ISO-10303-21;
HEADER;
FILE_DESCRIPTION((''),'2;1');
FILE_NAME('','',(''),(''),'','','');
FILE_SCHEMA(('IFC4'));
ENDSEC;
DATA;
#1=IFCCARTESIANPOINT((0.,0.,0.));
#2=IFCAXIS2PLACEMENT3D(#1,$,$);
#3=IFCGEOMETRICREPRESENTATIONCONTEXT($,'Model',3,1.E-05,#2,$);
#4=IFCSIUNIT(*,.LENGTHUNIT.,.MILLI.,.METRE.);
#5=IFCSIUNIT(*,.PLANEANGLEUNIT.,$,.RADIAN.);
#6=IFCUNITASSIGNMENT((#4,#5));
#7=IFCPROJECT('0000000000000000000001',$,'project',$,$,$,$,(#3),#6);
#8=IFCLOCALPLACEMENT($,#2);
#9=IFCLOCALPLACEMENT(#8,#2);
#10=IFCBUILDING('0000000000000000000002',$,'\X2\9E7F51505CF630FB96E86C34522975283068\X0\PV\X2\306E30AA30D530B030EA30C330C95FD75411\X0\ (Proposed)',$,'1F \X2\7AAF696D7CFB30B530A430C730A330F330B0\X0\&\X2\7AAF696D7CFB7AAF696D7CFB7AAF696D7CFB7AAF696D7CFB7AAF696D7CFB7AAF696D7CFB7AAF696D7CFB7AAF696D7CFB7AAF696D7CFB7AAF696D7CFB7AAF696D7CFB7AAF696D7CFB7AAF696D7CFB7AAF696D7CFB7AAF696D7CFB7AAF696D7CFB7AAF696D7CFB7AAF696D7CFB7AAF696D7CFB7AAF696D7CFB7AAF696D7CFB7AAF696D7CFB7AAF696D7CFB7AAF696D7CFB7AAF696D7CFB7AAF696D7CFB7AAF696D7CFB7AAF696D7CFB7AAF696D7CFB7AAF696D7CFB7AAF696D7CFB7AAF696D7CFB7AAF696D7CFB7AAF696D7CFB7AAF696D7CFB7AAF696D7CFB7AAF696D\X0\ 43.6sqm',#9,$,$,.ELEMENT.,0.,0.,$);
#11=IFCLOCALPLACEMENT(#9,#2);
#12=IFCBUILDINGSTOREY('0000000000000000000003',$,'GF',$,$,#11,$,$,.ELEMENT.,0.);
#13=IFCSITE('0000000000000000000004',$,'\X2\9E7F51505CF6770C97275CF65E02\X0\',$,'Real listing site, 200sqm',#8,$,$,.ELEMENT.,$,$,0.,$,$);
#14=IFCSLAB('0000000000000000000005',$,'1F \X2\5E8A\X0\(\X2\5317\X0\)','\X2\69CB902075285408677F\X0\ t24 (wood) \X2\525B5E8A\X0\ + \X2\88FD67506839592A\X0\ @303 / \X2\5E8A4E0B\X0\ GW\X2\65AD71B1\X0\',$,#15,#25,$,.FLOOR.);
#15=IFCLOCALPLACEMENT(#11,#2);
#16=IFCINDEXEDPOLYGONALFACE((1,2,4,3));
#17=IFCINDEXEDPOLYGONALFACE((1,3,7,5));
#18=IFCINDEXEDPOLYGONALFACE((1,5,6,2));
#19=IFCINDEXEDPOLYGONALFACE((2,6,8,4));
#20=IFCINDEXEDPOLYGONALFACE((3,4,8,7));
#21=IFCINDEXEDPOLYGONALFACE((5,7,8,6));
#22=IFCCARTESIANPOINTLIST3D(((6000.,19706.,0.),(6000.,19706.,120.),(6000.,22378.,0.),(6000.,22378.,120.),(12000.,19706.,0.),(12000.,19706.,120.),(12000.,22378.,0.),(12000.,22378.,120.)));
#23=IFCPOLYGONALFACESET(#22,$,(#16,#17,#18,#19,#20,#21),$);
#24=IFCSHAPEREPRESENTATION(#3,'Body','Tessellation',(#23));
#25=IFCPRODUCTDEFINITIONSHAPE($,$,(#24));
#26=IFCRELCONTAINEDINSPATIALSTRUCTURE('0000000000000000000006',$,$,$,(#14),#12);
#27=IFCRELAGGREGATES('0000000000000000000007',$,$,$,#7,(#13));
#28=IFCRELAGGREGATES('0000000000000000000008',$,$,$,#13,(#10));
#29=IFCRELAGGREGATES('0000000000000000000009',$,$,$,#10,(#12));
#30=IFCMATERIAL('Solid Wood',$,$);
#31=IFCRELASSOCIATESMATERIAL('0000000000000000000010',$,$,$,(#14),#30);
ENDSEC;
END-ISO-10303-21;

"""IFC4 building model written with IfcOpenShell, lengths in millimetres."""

from ifc_helpers import new_model, si_unit, frame, frame_2d, origin, place, context, project, spatial, rectangle, extrude, material, element, save


model = new_model("IFC4")

# Units and contexts
model_context = context("Model", 3, precision=1e-05, world=origin())
ifc_project = project(units=[si_unit("LENGTHUNIT", "METRE", prefix="MILLI"), si_unit("PLANEANGLEUNIT", "RADIAN")], contexts=[model_context])

# Site, building, storey
site_placement = place(None, origin())
site = spatial("IfcSite", under=ifc_project, at=site_placement, Name="鹿児島県霧島市", ObjectType="Real listing site, 200sqm", CompositionType="ELEMENT", RefElevation=0.0)
building_placement = place(site_placement, origin())
building = spatial("IfcBuilding", under=site, at=building_placement, Name="鹿児島・雨水利用とPVのオフグリッド志向 (Proposed)", ObjectType="1F 窯業系サイディング&窯業系窯業系窯業系窯業系窯業系窯業系窯業系窯業系窯業系窯業系窯業系窯業系窯業系窯業系窯業系窯業系窯業系窯業系窯業系窯業系窯業系窯業系窯業系窯業系窯業系窯業系窯業系窯業系窯業系窯業系窯業系窯業系窯業系窯業系窯業系窯業系窯業 43.6sqm", CompositionType="ELEMENT", ElevationOfRefHeight=0.0, ElevationOfTerrain=0.0)
storey_placement = place(building_placement, origin())
storey = spatial("IfcBuildingStorey", under=building, at=storey_placement, Name="GF", CompositionType="ELEMENT", Elevation=0.0)

# Shared definitions
ifc_material_1 = material(Name="Solid Wood")

# Slab
slab_1_placement = place(storey_placement, frame((3000.0, 9853.0, 0.0)))
element("IfcSlab", 1, at=slab_1_placement, inside=storey, material=ifc_material_1, Name="1F 床(北)", Description="構造用合板 t24 (wood) 剛床 + 製材根太 @303 / 床下 GW断熱", PredefinedType="FLOOR", context=model_context, shape_type="SweptSolid", body=[
    extrude(rectangle(XDim=6000.0, YDim=2672.0, at=frame_2d((3000.0, 1336.0))), frame((3000.0, 9853.0, 0.0)), (0.0, 0.0, 1.0), 120.0),
])

save(model, "model.ifc")
